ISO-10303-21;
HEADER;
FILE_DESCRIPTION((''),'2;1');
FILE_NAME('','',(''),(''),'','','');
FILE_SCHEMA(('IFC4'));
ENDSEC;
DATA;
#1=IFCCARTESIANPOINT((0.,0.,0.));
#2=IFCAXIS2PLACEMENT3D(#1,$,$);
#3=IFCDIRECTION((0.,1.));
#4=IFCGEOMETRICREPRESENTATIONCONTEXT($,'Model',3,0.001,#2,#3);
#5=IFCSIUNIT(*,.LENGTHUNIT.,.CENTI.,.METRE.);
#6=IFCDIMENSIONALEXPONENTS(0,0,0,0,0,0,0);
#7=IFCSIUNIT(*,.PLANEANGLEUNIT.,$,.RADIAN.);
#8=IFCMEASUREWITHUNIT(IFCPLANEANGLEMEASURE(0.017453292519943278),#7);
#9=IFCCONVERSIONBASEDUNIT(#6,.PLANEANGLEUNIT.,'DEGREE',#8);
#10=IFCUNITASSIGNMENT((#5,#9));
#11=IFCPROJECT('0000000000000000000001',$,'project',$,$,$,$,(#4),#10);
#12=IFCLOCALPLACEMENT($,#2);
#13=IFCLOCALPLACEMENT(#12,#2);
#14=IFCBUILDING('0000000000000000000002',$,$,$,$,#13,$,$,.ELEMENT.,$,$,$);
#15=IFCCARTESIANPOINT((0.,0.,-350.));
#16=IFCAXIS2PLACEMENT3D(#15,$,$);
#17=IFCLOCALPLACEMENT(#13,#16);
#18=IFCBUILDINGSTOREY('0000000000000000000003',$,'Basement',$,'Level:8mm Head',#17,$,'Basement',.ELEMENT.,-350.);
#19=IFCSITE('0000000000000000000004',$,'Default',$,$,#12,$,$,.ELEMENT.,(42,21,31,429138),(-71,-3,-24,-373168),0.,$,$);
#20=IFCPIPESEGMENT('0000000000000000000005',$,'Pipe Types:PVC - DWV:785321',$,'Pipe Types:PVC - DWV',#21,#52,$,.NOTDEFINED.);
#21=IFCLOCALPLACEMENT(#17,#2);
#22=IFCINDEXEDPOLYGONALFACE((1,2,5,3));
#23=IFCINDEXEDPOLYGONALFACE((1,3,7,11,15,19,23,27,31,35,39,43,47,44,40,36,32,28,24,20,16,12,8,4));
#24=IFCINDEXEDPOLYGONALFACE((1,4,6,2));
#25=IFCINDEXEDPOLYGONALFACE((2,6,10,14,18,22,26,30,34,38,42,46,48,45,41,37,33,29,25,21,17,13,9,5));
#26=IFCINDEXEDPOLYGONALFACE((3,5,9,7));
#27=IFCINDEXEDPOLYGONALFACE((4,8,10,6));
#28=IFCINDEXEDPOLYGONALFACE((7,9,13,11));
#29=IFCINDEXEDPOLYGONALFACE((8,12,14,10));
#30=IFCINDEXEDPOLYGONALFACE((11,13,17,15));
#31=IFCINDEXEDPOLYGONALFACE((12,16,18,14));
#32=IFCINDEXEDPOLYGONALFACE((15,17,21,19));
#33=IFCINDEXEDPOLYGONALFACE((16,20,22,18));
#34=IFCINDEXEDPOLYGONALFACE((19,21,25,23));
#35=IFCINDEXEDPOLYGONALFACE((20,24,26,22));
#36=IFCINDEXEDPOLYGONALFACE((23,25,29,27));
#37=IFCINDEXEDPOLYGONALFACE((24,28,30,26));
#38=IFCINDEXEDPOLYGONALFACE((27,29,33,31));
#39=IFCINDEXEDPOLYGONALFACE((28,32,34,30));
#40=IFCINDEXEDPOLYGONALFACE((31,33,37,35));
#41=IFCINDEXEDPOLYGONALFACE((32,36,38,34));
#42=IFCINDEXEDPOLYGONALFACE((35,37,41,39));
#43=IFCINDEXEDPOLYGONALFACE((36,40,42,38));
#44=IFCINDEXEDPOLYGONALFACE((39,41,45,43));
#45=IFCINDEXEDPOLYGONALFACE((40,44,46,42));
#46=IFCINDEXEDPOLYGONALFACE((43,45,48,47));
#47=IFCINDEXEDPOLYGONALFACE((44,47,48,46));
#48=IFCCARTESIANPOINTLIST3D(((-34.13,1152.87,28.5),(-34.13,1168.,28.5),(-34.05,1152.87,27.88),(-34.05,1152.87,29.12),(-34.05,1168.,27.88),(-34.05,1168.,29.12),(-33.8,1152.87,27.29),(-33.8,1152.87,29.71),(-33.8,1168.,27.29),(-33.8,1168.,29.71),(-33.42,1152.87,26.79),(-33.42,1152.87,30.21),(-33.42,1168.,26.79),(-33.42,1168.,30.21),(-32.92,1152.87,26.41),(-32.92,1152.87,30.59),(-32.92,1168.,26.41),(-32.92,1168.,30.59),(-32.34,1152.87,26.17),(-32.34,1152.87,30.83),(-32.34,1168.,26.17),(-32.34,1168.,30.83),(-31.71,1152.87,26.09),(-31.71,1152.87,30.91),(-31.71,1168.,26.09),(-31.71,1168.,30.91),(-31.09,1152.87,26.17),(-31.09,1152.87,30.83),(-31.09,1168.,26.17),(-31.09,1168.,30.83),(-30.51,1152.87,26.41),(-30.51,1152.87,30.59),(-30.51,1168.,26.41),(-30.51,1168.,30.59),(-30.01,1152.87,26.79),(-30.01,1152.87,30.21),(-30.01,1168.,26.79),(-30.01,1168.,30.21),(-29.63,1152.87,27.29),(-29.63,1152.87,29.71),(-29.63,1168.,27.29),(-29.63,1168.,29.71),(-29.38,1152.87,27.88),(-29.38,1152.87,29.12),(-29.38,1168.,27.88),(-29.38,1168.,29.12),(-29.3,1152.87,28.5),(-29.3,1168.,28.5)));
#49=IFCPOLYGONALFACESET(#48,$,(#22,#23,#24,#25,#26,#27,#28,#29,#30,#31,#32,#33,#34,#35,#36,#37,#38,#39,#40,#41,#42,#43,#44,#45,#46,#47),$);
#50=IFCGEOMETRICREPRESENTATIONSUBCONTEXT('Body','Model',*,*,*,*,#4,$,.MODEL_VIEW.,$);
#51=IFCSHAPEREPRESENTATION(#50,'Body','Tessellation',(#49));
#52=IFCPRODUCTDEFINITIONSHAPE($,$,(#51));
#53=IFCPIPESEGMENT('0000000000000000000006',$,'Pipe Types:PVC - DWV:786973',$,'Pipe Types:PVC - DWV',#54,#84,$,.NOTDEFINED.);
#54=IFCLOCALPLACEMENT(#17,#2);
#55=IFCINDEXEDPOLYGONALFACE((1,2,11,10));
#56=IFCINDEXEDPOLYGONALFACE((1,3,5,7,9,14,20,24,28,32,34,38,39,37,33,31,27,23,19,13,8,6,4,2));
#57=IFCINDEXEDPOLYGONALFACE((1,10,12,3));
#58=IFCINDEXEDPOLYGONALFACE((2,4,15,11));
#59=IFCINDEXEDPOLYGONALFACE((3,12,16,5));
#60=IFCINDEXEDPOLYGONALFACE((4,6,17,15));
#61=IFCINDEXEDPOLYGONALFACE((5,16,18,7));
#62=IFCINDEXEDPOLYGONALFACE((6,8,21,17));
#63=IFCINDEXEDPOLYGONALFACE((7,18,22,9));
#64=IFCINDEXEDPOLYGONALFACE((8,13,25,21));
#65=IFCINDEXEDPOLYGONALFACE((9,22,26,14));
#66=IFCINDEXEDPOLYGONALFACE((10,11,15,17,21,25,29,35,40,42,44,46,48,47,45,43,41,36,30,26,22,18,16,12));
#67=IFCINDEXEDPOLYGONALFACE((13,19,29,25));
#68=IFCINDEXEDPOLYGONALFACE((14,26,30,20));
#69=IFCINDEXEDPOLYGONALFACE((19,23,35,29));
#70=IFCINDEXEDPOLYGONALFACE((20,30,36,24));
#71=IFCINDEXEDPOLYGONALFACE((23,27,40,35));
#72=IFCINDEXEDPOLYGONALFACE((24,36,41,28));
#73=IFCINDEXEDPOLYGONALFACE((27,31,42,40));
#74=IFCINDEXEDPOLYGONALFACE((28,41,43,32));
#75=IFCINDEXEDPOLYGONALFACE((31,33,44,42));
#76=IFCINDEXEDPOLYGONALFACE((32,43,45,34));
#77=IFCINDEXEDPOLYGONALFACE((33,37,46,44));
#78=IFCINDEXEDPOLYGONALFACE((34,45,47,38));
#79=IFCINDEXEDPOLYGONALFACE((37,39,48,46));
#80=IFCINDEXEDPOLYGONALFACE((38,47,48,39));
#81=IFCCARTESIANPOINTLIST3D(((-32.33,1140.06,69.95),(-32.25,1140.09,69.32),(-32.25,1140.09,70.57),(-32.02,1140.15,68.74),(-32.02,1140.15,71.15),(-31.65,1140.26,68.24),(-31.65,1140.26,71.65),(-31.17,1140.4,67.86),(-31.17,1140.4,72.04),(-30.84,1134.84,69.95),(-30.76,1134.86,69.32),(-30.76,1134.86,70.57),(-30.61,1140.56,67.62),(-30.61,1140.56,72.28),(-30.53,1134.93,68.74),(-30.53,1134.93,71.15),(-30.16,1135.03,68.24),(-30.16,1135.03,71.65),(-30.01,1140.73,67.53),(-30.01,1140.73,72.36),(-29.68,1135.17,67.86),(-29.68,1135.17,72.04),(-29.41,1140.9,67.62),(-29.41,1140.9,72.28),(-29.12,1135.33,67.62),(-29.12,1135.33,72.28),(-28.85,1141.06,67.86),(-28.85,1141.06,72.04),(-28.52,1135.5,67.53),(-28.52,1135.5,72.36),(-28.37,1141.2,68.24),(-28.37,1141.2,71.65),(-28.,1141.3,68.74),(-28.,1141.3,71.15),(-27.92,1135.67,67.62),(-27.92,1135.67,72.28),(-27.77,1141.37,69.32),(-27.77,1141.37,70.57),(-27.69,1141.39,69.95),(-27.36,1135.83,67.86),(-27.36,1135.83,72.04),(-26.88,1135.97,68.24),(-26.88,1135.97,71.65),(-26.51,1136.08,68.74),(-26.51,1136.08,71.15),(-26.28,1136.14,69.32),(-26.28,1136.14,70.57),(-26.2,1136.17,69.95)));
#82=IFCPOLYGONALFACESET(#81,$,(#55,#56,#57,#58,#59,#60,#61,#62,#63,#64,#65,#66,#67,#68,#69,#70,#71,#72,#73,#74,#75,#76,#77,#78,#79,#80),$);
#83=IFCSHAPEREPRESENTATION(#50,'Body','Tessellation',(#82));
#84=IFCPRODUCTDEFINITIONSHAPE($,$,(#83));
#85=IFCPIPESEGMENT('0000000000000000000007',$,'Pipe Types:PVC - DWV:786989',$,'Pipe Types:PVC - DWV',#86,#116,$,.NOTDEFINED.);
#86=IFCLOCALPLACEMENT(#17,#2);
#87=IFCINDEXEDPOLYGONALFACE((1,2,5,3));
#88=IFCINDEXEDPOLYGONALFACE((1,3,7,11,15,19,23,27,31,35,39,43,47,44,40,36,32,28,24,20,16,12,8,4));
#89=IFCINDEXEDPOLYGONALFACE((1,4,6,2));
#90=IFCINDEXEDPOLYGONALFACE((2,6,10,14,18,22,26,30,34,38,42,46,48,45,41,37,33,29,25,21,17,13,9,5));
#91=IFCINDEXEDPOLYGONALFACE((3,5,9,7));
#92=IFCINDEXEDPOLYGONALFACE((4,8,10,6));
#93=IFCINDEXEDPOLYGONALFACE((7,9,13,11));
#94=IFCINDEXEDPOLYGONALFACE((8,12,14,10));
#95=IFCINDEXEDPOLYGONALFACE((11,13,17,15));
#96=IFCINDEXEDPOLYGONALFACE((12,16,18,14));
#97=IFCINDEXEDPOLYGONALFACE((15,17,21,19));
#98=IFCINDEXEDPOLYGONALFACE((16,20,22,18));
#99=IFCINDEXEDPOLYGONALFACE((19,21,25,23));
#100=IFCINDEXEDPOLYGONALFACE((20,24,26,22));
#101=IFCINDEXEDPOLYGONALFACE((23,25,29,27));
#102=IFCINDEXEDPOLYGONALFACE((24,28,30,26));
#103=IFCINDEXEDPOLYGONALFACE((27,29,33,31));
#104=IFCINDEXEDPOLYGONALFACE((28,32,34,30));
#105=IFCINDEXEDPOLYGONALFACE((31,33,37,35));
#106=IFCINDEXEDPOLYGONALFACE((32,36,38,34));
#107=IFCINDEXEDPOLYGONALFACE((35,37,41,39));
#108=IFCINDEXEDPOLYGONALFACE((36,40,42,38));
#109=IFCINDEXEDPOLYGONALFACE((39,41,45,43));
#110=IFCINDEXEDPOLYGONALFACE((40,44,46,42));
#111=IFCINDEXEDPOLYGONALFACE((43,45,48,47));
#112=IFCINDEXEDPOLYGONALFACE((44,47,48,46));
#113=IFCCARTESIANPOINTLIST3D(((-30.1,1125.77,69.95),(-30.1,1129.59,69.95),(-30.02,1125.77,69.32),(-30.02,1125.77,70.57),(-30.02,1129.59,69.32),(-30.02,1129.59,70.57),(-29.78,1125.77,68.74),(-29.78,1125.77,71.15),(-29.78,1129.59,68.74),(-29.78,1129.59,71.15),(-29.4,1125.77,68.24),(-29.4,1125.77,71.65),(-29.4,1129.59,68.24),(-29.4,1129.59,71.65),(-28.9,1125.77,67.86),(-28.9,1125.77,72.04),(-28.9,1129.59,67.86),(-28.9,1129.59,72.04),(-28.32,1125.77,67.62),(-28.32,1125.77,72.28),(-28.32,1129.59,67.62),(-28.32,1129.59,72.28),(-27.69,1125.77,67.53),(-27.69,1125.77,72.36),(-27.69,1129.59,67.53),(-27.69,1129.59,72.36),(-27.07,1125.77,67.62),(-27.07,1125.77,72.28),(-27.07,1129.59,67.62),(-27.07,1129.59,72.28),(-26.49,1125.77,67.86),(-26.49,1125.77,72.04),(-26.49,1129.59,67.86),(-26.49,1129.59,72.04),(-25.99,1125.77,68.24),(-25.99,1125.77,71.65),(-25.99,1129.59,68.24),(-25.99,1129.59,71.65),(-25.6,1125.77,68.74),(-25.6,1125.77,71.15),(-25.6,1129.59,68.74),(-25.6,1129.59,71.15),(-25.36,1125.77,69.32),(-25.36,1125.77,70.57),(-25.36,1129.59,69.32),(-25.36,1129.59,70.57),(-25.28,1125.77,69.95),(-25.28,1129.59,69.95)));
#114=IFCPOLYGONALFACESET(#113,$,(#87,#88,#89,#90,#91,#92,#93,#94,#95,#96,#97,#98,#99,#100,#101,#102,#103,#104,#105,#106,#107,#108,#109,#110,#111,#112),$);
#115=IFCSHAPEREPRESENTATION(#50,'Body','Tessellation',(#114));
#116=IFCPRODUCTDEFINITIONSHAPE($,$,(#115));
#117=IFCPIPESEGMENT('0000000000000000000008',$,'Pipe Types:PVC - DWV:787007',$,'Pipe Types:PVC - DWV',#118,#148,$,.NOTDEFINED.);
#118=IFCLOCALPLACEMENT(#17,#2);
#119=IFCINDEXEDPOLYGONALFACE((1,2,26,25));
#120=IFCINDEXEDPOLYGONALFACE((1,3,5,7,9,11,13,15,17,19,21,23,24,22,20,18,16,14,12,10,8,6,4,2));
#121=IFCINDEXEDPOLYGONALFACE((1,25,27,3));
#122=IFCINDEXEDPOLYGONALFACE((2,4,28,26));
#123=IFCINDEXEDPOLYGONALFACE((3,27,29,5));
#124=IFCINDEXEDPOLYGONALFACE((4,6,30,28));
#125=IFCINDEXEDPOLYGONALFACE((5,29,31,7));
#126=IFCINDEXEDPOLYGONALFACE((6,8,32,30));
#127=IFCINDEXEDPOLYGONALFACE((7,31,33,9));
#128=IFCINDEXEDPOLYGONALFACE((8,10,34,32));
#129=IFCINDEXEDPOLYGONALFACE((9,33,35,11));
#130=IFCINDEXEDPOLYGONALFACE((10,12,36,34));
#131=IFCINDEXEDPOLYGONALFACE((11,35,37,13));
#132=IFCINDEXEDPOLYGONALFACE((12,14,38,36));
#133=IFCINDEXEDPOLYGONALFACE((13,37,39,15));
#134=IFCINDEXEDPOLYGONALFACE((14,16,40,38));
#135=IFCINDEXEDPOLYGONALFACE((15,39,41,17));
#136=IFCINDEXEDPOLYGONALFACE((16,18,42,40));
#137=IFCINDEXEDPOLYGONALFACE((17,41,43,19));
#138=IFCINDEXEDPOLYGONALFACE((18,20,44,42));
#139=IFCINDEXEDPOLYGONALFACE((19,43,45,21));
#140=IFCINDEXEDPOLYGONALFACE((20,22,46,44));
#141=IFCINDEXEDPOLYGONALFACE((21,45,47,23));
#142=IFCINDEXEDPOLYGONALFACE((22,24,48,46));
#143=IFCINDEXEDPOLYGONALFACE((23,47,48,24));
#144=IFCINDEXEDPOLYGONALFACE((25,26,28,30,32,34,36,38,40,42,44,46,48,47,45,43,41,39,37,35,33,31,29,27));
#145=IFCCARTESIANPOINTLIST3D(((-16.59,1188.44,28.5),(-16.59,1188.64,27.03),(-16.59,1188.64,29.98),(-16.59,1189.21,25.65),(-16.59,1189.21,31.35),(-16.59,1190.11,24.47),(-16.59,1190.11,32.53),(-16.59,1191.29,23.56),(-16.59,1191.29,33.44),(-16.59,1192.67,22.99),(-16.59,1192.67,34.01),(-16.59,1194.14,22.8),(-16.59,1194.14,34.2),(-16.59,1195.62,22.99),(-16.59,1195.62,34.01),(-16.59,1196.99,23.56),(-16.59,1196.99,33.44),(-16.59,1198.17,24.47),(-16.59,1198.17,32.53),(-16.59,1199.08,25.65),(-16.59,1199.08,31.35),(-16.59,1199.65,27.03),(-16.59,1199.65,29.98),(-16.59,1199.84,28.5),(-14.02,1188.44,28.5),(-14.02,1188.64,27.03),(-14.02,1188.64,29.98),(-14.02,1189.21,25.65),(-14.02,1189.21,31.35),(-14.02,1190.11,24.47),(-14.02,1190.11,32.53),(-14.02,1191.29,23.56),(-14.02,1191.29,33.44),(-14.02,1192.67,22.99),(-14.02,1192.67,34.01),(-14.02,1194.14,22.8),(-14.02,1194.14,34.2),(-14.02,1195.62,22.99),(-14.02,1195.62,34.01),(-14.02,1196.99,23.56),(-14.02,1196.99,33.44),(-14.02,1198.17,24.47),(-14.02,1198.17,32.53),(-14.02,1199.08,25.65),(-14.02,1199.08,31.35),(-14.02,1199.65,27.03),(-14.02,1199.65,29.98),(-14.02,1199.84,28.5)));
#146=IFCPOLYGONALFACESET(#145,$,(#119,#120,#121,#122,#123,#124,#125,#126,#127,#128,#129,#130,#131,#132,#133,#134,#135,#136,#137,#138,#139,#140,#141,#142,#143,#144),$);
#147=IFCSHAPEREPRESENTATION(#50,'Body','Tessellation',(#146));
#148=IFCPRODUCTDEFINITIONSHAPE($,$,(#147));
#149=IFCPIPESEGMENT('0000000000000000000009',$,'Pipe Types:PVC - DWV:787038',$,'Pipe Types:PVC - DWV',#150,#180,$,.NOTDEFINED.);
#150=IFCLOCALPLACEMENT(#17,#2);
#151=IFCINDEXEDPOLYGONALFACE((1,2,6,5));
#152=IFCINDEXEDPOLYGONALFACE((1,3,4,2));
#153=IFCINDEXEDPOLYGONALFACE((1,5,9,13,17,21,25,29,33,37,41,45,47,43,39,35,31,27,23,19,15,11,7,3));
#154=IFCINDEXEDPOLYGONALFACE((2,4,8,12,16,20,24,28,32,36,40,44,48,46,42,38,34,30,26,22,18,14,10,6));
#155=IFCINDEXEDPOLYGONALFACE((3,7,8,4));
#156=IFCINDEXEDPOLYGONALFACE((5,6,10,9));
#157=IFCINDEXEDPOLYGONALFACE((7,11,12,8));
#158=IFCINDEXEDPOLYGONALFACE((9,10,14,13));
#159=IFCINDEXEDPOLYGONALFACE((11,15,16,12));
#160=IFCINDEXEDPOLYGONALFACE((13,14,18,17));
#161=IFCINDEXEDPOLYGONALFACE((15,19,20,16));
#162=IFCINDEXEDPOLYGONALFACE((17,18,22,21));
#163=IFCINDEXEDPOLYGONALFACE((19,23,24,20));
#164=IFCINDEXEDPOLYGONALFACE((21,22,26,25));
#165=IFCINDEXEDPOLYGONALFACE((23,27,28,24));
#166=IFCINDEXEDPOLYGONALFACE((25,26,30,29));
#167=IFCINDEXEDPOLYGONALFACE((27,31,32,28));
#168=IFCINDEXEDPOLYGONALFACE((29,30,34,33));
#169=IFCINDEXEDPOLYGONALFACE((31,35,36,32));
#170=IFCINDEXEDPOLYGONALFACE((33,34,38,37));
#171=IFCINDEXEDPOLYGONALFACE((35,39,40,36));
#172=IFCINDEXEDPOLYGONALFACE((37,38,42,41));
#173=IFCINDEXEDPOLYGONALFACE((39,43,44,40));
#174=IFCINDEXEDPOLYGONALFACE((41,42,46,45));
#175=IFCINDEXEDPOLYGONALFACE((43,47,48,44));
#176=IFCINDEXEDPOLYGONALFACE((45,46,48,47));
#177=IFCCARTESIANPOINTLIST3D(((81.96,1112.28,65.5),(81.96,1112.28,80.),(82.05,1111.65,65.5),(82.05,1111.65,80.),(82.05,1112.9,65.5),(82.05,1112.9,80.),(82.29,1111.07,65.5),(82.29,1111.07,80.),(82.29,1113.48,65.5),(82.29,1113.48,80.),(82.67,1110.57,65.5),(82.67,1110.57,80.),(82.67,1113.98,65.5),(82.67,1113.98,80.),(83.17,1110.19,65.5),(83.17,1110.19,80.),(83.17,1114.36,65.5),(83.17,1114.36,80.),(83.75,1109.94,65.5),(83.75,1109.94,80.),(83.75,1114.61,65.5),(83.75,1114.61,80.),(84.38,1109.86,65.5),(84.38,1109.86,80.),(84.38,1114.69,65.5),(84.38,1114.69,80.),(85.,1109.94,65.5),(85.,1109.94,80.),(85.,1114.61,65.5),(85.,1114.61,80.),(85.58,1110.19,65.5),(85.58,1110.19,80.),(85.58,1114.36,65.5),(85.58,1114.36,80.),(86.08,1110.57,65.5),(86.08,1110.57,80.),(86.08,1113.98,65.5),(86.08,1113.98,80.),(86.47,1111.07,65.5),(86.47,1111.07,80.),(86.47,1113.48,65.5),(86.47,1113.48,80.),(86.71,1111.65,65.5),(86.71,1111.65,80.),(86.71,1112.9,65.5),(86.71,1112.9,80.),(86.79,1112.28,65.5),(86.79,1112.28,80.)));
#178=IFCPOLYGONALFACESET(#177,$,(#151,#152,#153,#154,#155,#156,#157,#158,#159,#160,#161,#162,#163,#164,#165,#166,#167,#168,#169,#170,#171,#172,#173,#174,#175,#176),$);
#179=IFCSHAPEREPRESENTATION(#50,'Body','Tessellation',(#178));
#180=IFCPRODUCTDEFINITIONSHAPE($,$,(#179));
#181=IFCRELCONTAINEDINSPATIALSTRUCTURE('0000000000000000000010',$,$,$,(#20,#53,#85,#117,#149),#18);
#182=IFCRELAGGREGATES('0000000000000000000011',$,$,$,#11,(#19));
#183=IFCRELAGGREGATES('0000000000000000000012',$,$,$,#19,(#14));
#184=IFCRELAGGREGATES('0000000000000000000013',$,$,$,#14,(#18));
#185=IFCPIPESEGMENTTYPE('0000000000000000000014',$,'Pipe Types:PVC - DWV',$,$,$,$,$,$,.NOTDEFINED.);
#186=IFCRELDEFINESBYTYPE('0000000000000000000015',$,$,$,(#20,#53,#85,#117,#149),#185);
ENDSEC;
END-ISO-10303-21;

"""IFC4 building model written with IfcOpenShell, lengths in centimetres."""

from ifc_helpers import new_model, entity, si_unit, converted_unit, direction, frame, origin, place, context, subcontext, project, spatial, arc, indexed_curve, outline, extrude, type_object, element, save


model = new_model("IFC4")

# Units and contexts
model_context = context("Model", 3, precision=0.001, world=origin(), true_north=direction((0.0, 1.0)))
body_context = subcontext(model_context, "Body", "Model", "MODEL_VIEW")
ifc_project = project(units=[si_unit("LENGTHUNIT", "METRE", prefix="CENTI"), converted_unit("PLANEANGLEUNIT", "DEGREE", entity("IfcPlaneAngleMeasure", 0.017453292519943278), si_unit("PLANEANGLEUNIT", "RADIAN"), dimensions=[0, 0, 0, 0, 0, 0, 0])], contexts=[model_context])

# Site, building, storey
site_placement = place(None, origin())
site = spatial("IfcSite", under=ifc_project, at=site_placement, Name="Default", CompositionType="ELEMENT", RefLatitude=(42, 21, 31, 429138), RefLongitude=(-71, -3, -24, -373168), RefElevation=0.0)
building_placement = place(site_placement, origin())
building = spatial("IfcBuilding", under=site, at=building_placement, CompositionType="ELEMENT")
storey_placement = place(building_placement, frame((0.0, 0.0, -350.0)))
storey = spatial("IfcBuildingStorey", under=building, at=storey_placement, Name="Basement", ObjectType="Level:8mm Head", LongName="Basement", CompositionType="ELEMENT", Elevation=-350.0)

# Pipe segments
pipe_segment_type = type_object("IfcPipeSegmentType", Name="Pipe Types:PVC - DWV", PredefinedType="NOTDEFINED")
pipe_segment_1_placement = place(storey_placement, origin())
element("IfcPipeSegment", 1, at=pipe_segment_1_placement, inside=storey, type_object=pipe_segment_type, Name="Pipe Types:PVC - DWV:785321", ObjectType="Pipe Types:PVC - DWV", PredefinedType="NOTDEFINED", context=body_context, shape_type="SweptSolid", body=[
    extrude(outline(indexed_curve([(2.41, 0.0), (1.71, 1.71), (0.0, 2.41), (-1.71, 1.71), (-2.41, 0.0), (-1.71, -1.71), (0.0, -2.41), (1.71, -1.71)], segments=[arc(1, 2, 3), arc(3, 4, 5), arc(5, 6, 7), arc(7, 8, 1)], self_intersect=False)), frame((-31.71, 1152.87, 28.5), z_axis=(0.0, 1.0, 0.0), x_axis=(1.0, 0.0, 0.0)), (0.0, 0.0, 1.0), 15.13),
])
pipe_segment_2_placement = place(storey_placement, origin())
element("IfcPipeSegment", 2, at=pipe_segment_2_placement, inside=storey, type_object=pipe_segment_type, Name="Pipe Types:PVC - DWV:786973", ObjectType="Pipe Types:PVC - DWV", PredefinedType="NOTDEFINED", context=body_context, shape_type="SweptSolid", body=[
    extrude(outline(indexed_curve([(2.41, 0.0), (1.71, 1.71), (0.0, 2.41), (-1.71, 1.71), (-2.41, 0.0), (-1.71, -1.71), (0.0, -2.41), (1.71, -1.71)], segments=[arc(1, 2, 3), arc(3, 4, 5), arc(5, 6, 7), arc(7, 8, 1)], self_intersect=False)), frame((-30.01, 1140.73, 69.95), z_axis=(0.274825, -0.961494, 0.0), x_axis=(0.961494, 0.274825, 0.0)), (0.0, 0.0, 1.0), 5.43),
])
pipe_segment_3_placement = place(storey_placement, origin())
element("IfcPipeSegment", 3, at=pipe_segment_3_placement, inside=storey, type_object=pipe_segment_type, Name="Pipe Types:PVC - DWV:786989", ObjectType="Pipe Types:PVC - DWV", PredefinedType="NOTDEFINED", context=body_context, shape_type="SweptSolid", body=[
    extrude(outline(indexed_curve([(2.41, 0.0), (1.71, 1.71), (0.0, 2.41), (-1.71, 1.71), (-2.41, 0.0), (-1.71, -1.71), (0.0, -2.41), (1.71, -1.71)], segments=[arc(1, 2, 3), arc(3, 4, 5), arc(5, 6, 7), arc(7, 8, 1)], self_intersect=False)), frame((-27.69, 1125.77, 69.95), z_axis=(0.0, 1.0, 0.0), x_axis=(1.0, 0.0, 0.0)), (0.0, 0.0, 1.0), 3.82),
])
pipe_segment_4_placement = place(storey_placement, origin())
element("IfcPipeSegment", 4, at=pipe_segment_4_placement, inside=storey, type_object=pipe_segment_type, Name="Pipe Types:PVC - DWV:787007", ObjectType="Pipe Types:PVC - DWV", PredefinedType="NOTDEFINED", context=body_context, shape_type="SweptSolid", body=[
    extrude(outline(indexed_curve([(5.7, 0.0), (4.03, 4.03), (0.0, 5.7), (-4.03, 4.03), (-5.7, 0.0), (-4.03, -4.03), (0.0, -5.7), (4.03, -4.03)], segments=[arc(1, 2, 3), arc(3, 4, 5), arc(5, 6, 7), arc(7, 8, 1)], self_intersect=False)), frame((-16.59, 1194.14, 28.5), z_axis=(1.0, 0.0, 0.0), x_axis=(0.0, -1.0, 0.0)), (0.0, 0.0, 1.0), 2.58),
])
pipe_segment_5_placement = place(storey_placement, origin())
element("IfcPipeSegment", 5, at=pipe_segment_5_placement, inside=storey, type_object=pipe_segment_type, Name="Pipe Types:PVC - DWV:787038", ObjectType="Pipe Types:PVC - DWV", PredefinedType="NOTDEFINED", context=body_context, shape_type="SweptSolid", body=[
    extrude(outline(indexed_curve([(2.41, 0.0), (1.71, 1.71), (0.0, 2.41), (-1.71, 1.71), (-2.41, 0.0), (-1.71, -1.71), (0.0, -2.41), (1.71, -1.71)], segments=[arc(1, 2, 3), arc(3, 4, 5), arc(5, 6, 7), arc(7, 8, 1)], self_intersect=False)), frame((84.38, 1112.28, 65.5), z_axis=(0.0, 0.0, 1.0), x_axis=(-1.0, 0.0, 0.0)), (0.0, 0.0, 1.0), 14.5),
])

save(model, "model.ifc")
